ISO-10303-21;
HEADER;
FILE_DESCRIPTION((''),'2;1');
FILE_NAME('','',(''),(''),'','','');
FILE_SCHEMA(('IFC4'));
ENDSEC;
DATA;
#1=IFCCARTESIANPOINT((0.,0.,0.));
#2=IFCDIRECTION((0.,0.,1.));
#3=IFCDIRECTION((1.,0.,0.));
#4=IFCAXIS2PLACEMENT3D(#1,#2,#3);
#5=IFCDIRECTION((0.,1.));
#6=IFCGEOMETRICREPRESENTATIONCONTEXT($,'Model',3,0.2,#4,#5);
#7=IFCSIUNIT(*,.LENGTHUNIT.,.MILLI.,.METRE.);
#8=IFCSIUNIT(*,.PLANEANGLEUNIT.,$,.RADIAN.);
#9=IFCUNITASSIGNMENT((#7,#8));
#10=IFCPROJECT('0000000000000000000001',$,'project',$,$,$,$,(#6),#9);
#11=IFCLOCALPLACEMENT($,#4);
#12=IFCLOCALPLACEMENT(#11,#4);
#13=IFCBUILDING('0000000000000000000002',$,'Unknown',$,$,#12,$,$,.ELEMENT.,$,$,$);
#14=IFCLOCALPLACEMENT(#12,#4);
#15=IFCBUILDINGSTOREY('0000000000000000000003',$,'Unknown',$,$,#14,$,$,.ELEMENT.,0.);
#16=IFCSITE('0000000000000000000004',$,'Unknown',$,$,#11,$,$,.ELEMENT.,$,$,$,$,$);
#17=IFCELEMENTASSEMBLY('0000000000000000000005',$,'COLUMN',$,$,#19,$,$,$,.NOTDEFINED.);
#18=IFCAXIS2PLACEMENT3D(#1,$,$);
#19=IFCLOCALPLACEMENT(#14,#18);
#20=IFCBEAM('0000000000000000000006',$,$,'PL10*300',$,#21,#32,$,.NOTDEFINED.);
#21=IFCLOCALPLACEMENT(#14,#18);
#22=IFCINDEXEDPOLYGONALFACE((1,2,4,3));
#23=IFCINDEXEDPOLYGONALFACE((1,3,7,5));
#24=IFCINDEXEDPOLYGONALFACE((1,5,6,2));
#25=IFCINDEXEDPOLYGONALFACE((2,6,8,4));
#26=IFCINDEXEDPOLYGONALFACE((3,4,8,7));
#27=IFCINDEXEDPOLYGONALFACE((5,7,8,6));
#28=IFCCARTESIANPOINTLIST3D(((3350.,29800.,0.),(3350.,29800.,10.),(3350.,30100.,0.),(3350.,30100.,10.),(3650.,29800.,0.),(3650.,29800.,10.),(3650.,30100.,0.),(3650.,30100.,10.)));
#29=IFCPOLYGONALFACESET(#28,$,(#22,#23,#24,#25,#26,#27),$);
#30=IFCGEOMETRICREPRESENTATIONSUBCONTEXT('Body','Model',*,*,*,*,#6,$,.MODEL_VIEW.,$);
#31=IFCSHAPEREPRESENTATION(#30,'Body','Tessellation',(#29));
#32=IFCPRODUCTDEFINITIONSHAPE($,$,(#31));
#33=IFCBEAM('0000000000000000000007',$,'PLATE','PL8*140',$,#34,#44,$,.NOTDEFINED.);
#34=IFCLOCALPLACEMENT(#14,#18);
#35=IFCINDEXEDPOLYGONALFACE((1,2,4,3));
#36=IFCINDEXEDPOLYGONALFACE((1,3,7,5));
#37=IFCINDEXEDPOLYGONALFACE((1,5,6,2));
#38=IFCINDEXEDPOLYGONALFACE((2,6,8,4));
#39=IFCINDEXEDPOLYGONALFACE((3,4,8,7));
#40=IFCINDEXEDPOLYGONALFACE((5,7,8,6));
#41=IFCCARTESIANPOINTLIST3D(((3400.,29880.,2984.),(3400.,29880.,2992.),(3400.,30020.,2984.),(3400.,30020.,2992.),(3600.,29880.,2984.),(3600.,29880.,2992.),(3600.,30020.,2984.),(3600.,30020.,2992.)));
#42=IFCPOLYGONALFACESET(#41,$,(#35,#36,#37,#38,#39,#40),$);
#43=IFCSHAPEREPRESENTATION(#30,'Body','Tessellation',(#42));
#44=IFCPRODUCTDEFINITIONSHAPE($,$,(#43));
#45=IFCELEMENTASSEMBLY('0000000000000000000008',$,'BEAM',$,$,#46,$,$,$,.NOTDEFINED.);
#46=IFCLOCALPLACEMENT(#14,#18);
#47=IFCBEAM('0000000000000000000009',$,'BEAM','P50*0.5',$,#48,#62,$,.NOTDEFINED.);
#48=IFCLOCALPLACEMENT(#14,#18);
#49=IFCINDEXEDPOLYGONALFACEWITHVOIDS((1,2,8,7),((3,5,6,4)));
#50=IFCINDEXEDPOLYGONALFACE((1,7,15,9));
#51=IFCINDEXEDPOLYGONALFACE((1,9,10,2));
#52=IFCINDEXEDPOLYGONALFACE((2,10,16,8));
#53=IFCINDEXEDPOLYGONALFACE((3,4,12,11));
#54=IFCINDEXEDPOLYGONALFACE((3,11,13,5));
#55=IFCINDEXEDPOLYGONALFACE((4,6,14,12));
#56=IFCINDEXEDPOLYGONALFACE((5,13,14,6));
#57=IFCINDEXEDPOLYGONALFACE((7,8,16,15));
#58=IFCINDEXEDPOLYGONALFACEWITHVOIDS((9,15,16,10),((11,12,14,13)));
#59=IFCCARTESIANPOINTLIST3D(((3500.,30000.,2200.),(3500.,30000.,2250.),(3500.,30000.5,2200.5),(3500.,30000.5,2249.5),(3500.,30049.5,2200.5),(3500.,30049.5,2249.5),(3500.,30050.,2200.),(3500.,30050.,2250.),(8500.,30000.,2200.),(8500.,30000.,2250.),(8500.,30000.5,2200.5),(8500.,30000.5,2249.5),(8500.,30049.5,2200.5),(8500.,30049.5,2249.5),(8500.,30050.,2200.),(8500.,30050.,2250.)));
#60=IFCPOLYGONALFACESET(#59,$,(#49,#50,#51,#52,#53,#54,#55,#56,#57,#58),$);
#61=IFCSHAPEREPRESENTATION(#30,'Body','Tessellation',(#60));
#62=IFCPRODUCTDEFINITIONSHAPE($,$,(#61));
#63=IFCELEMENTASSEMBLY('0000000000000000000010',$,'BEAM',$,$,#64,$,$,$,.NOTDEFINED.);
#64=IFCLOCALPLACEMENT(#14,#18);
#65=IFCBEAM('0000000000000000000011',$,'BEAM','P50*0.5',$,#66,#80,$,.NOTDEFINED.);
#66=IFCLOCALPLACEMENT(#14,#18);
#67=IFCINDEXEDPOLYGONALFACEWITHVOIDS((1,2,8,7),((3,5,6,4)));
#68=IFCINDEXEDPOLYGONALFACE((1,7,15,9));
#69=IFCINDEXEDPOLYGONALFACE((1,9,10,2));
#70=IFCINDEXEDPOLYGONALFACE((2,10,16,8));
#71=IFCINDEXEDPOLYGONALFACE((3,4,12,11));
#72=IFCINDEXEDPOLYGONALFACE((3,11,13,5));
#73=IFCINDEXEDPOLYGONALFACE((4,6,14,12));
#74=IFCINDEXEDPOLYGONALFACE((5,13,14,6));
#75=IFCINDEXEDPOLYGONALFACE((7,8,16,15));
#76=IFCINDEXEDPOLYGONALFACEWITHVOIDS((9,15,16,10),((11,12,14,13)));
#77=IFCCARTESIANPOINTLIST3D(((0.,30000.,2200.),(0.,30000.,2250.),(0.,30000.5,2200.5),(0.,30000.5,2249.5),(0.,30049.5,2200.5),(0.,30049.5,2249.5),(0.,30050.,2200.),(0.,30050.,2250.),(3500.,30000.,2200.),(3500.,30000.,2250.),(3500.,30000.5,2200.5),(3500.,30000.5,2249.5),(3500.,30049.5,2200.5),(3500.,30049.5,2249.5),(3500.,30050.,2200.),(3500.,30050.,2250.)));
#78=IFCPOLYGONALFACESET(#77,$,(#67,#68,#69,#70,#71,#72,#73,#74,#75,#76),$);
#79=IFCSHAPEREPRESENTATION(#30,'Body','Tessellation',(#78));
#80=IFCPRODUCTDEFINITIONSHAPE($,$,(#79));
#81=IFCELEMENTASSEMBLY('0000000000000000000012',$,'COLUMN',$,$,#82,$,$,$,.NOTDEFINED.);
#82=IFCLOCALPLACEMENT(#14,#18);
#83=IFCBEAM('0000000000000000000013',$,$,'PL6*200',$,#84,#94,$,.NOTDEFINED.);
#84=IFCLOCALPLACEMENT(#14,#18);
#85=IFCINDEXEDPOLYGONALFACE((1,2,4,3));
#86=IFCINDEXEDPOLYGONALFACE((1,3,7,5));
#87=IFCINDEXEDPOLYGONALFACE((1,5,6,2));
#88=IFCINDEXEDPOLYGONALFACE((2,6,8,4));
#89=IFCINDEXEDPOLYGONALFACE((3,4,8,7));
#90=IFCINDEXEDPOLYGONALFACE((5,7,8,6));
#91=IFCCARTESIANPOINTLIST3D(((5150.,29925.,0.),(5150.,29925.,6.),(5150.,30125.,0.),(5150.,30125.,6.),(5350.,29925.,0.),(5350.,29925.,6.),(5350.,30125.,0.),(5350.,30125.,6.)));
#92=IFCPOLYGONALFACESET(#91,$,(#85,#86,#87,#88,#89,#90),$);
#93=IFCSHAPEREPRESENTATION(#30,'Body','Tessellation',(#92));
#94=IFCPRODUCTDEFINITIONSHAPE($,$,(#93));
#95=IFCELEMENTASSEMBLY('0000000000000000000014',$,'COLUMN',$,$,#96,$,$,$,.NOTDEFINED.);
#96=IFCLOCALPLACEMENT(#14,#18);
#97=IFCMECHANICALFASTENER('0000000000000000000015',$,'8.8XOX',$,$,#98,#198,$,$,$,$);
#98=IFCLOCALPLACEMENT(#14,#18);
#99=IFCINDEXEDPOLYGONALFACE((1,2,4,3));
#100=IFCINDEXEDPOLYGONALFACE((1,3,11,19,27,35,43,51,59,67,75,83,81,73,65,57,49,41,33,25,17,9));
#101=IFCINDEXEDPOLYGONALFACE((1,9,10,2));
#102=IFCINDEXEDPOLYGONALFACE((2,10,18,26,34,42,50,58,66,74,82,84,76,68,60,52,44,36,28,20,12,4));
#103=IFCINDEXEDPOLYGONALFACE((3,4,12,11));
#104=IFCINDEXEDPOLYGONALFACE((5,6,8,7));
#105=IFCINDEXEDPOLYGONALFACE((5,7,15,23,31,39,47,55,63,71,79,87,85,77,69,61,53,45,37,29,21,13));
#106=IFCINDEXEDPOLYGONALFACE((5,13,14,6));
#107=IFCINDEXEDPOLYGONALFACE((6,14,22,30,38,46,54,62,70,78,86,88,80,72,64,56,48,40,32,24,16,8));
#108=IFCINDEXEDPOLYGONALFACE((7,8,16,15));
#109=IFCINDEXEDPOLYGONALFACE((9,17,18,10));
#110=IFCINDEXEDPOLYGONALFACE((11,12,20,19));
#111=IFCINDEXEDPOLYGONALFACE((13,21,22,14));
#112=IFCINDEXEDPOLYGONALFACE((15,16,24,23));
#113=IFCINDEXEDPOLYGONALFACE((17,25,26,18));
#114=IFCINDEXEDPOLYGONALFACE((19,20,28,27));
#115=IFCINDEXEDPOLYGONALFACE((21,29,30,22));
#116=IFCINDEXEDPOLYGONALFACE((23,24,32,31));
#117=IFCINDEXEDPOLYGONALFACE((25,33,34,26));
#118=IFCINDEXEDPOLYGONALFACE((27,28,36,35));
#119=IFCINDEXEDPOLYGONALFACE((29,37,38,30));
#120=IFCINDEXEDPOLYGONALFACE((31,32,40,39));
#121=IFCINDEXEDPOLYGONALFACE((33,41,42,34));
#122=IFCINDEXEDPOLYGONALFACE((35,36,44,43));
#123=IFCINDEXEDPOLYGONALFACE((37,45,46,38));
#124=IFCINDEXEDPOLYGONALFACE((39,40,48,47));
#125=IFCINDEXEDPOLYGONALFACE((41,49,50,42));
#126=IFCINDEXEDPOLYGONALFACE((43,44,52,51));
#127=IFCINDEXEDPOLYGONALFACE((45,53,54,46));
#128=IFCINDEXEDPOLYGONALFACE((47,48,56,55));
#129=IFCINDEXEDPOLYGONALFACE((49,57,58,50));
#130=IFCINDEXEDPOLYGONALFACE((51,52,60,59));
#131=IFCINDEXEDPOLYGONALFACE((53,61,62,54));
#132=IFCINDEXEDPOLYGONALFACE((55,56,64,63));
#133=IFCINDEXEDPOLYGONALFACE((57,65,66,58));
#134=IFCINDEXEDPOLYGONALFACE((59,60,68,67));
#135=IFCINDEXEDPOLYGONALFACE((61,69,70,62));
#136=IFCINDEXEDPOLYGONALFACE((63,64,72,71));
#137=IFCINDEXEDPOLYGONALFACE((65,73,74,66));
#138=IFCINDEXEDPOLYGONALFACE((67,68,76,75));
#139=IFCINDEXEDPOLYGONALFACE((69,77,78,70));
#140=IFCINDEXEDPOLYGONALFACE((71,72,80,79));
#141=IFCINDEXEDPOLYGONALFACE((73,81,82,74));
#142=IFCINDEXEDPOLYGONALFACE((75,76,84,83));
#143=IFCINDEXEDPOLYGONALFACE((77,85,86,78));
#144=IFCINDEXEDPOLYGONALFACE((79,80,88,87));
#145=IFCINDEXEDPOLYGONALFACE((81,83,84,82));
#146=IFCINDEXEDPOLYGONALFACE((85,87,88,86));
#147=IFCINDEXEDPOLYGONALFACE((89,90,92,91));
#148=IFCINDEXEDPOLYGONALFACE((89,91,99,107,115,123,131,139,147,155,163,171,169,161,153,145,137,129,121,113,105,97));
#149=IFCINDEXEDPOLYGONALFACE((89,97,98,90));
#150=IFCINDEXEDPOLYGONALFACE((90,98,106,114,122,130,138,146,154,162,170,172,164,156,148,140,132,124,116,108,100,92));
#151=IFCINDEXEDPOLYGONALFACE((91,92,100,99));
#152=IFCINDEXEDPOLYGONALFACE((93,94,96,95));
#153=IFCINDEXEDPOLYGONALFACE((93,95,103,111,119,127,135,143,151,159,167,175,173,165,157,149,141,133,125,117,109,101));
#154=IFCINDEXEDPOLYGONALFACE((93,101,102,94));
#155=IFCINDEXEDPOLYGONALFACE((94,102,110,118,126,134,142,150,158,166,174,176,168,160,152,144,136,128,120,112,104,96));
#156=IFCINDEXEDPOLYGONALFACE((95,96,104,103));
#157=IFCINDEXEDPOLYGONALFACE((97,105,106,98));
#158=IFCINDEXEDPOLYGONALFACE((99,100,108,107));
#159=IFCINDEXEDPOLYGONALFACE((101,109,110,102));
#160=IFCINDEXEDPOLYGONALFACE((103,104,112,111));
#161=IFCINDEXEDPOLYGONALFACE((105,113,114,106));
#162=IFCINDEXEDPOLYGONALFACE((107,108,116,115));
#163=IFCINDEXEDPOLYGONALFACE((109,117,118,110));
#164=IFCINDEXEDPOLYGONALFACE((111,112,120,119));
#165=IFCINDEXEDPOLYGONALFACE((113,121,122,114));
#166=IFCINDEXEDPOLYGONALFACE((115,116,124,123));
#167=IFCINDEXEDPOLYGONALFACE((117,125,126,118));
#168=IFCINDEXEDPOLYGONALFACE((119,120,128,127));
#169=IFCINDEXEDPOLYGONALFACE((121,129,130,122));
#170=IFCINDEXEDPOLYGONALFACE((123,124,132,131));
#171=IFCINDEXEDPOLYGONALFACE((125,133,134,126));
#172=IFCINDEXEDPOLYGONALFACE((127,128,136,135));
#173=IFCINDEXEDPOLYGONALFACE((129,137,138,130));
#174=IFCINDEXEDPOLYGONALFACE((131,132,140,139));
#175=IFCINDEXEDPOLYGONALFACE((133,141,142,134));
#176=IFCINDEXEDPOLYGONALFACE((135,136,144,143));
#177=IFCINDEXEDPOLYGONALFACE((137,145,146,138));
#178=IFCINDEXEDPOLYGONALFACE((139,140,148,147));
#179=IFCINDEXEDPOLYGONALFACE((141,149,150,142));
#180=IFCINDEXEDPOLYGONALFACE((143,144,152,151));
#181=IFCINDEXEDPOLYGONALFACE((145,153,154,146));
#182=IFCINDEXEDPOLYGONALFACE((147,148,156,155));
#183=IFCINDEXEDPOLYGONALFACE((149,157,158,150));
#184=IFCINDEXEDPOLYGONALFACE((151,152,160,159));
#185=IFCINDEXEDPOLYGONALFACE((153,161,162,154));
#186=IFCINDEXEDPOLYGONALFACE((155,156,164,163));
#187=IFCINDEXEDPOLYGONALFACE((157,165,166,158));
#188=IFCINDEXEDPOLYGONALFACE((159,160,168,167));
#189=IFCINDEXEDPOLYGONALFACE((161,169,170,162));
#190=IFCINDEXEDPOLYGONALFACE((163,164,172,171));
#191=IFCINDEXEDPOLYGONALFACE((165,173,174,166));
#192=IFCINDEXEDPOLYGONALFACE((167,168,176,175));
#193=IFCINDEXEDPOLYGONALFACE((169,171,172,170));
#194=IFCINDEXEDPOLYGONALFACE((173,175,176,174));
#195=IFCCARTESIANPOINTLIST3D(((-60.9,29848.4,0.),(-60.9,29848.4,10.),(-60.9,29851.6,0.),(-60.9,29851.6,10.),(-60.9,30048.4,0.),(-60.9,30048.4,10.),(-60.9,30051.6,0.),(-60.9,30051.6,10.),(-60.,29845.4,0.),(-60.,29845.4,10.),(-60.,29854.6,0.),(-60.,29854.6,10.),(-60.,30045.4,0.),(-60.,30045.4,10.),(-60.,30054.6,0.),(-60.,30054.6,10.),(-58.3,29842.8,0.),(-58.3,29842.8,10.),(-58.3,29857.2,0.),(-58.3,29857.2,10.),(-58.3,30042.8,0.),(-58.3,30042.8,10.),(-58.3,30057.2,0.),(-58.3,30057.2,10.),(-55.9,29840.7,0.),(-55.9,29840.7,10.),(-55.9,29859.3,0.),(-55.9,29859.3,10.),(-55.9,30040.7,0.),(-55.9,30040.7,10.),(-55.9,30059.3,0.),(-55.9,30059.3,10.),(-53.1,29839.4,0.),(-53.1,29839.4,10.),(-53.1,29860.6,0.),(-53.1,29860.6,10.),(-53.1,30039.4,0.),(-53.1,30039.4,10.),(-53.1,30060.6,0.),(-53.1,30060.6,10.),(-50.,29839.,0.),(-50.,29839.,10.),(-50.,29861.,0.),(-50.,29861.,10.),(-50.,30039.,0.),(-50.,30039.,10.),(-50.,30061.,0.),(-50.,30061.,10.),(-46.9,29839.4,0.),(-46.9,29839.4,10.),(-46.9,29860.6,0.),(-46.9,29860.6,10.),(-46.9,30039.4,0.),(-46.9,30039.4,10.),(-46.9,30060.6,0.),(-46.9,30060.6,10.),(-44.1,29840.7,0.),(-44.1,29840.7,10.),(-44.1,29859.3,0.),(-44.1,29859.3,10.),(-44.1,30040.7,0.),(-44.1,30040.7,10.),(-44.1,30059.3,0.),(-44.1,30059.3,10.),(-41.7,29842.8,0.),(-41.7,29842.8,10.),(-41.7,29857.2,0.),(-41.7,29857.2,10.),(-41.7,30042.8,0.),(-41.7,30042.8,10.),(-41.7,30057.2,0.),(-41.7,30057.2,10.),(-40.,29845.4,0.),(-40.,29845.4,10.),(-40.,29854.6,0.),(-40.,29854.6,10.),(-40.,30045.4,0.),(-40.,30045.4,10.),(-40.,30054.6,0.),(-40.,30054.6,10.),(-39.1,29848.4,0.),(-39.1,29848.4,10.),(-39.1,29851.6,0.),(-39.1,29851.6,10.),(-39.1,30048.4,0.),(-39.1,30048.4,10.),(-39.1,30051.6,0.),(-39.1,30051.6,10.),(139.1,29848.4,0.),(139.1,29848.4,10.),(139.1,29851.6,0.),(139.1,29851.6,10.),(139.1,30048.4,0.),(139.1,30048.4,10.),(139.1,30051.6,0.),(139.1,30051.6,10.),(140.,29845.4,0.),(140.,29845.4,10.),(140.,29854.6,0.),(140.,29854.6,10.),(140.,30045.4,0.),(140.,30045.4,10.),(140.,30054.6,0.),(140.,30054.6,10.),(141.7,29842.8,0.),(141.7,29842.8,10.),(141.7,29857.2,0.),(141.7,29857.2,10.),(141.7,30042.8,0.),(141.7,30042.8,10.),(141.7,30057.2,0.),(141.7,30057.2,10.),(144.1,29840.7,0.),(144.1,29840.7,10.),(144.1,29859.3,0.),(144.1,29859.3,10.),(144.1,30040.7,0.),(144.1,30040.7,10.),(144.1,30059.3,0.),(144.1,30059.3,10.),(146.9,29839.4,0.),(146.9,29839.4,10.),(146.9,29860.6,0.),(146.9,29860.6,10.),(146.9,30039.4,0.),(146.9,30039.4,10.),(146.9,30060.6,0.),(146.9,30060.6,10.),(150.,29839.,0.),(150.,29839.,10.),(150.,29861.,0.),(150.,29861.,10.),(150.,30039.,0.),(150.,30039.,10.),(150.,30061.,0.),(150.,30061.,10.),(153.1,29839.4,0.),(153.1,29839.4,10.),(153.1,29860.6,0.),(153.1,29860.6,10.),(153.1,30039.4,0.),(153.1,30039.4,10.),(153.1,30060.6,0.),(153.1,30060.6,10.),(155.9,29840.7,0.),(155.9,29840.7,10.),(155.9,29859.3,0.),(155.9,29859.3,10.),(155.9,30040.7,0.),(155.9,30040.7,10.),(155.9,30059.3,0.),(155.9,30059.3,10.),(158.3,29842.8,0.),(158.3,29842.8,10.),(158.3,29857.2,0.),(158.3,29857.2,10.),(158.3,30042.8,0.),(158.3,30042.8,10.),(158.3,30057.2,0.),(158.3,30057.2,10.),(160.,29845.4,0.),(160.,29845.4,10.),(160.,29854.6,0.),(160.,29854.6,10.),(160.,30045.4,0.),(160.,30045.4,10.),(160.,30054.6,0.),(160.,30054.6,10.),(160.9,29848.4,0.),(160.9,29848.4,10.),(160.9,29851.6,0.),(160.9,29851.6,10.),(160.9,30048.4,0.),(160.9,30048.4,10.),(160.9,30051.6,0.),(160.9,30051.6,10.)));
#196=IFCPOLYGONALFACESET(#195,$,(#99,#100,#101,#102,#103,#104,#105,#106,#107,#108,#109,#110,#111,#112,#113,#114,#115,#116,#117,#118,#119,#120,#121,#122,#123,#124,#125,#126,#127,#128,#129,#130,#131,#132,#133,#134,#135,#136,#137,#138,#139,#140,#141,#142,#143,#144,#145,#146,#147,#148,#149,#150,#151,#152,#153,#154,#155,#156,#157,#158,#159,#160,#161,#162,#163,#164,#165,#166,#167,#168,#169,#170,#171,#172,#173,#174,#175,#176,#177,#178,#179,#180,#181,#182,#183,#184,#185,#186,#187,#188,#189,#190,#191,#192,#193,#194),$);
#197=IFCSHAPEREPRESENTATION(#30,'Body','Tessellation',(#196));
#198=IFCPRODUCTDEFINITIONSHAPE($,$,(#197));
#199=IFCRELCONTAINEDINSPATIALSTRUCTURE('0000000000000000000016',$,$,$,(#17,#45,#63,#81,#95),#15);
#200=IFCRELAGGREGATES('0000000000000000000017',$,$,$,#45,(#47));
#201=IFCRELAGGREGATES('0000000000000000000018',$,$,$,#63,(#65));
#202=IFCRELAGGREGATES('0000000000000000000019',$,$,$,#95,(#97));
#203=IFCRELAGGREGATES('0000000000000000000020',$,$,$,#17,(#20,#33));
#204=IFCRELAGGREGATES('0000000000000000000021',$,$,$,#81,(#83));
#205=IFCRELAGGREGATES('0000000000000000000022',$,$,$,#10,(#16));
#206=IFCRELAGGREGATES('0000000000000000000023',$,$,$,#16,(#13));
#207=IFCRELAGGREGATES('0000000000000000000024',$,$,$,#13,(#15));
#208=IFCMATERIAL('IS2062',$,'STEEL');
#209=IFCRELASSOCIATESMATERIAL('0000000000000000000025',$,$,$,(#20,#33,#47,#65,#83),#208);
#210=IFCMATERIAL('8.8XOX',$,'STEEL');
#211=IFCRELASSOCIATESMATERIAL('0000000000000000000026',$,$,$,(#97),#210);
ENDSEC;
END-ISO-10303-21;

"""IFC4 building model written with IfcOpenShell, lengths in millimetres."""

from ifc_helpers import new_model, si_unit, direction, frame, origin_with_axes, place, context, subcontext, project, spatial, line, arc, indexed_curve, outline, extrude, source, transform, mapped, material, element, aggregate, save


model = new_model("IFC4")

# Units and contexts
model_context = context("Model", 3, precision=0.2, world=origin_with_axes(), true_north=direction((0.0, 1.0)))
body_context = subcontext(model_context, "Body", "Model", "MODEL_VIEW")
ifc_project = project(units=[si_unit("LENGTHUNIT", "METRE", prefix="MILLI"), si_unit("PLANEANGLEUNIT", "RADIAN")], contexts=[model_context])

# Site, building, storey
site_placement = place(None, origin_with_axes())
site = spatial("IfcSite", under=ifc_project, at=site_placement, Name="Unknown", CompositionType="ELEMENT")
building_placement = place(site_placement, origin_with_axes())
building = spatial("IfcBuilding", under=site, at=building_placement, Name="Unknown", CompositionType="ELEMENT")
storey_placement = place(building_placement, origin_with_axes())
storey = spatial("IfcBuildingStorey", under=building, at=storey_placement, Name="Unknown", CompositionType="ELEMENT", Elevation=0.0)

# Shared definitions
ifc_material_1 = material(Name="IS2062", Category="STEEL")

# Element assembly, beams
assembly_1_placement = place(storey_placement, frame((3500.0, 29950.0, 0.0), z_axis=(0.0, 1.0, 0.0), x_axis=(0.0, 0.0, 1.0)))
assembly_1 = element("IfcElementAssembly", 1, at=assembly_1_placement, inside=storey, Name="COLUMN", PredefinedType="NOTDEFINED")
beam_1_placement = place(assembly_1_placement, frame((5.0, -150.0, 0.0), z_axis=(1.0, 0.0, 0.0), x_axis=(0.0, 1.0, 0.0)))
beam_1 = element("IfcBeam", 2, at=beam_1_placement, material=ifc_material_1, Description="PL10*300", PredefinedType="NOTDEFINED", context=body_context, shape_type="SolidModel", body=[
    extrude(outline(indexed_curve([(-5.0, -150.0), (5.0, -150.0), (5.0, 150.0), (-5.0, 150.0)], segments=[line(1, 2, 3, 4, 1)])), frame((0.0, 0.0, 0.0), z_axis=(-1.0, 0.0, 0.0), x_axis=(0.0, 0.0, 1.0)), (0.0, 0.0, -1.0), 300.0),
])
beam_2_placement = place(assembly_1_placement, frame((2988.0, -100.0, 0.0), z_axis=(-1.0, 0.0, 0.0), x_axis=(0.0, 1.0, 0.0)))
beam_2 = element("IfcBeam", 3, at=beam_2_placement, material=ifc_material_1, Name="PLATE", Description="PL8*140", PredefinedType="NOTDEFINED", context=body_context, shape_type="SolidModel", body=[
    extrude(outline(indexed_curve([(-4.0, -70.0), (4.0, -70.0), (4.0, 70.0), (-4.0, 70.0)], segments=[line(1, 2, 3, 4, 1)])), frame((0.0, 0.0, 0.0), z_axis=(-1.0, 0.0, 0.0), x_axis=(0.0, 0.0, 1.0)), (0.0, 0.0, -1.0), 200.0),
])

# Element assemblies, beams
assembly_2_placement = place(storey_placement, frame((3500.0, 30025.0, 2225.0), z_axis=(0.0, -1.0, 0.0), x_axis=(1.0, 0.0, 0.0)))
assembly_2 = element("IfcElementAssembly", 4, at=assembly_2_placement, inside=storey, Name="BEAM", PredefinedType="NOTDEFINED")
beam_3_placement = place(assembly_2_placement, origin_with_axes())
beam_3 = element("IfcBeam", 5, at=beam_3_placement, material=ifc_material_1, Name="BEAM", Description="P50*0.5", PredefinedType="NOTDEFINED", context=body_context, shape_type="SolidModel", body=[
    extrude(outline(indexed_curve([(-25.0, -25.0), (25.0, -25.0), (25.0, 25.0), (-25.0, 25.0)], segments=[line(1, 2, 3, 4, 1)]), holes=[indexed_curve([(-24.5, -24.5), (-24.5, 24.5), (24.5, 24.5), (24.5, -24.5)], segments=[line(1, 2, 3, 4, 1)])]), frame((0.0, 0.0, 0.0), z_axis=(-1.0, 0.0, 0.0), x_axis=(0.0, 0.0, 1.0)), (0.0, 0.0, -1.0), 5000.0),
])
aggregate(assembly_2, [beam_3])
assembly_3_placement = place(storey_placement, frame((3500.0, 30025.0, 2225.0), z_axis=(0.0, 1.0, 0.0), x_axis=(-1.0, 0.0, 0.0)))
assembly_3 = element("IfcElementAssembly", 6, at=assembly_3_placement, inside=storey, Name="BEAM", PredefinedType="NOTDEFINED")
beam_4_placement = place(assembly_3_placement, origin_with_axes())
beam_4 = element("IfcBeam", 7, at=beam_4_placement, material=ifc_material_1, Name="BEAM", Description="P50*0.5", PredefinedType="NOTDEFINED", context=body_context, shape_type="SolidModel", body=[
    extrude(outline(indexed_curve([(-25.0, -25.0), (25.0, -25.0), (25.0, 25.0), (-25.0, 25.0)], segments=[line(1, 2, 3, 4, 1)]), holes=[indexed_curve([(-24.5, -24.5), (-24.5, 24.5), (24.5, 24.5), (24.5, -24.5)], segments=[line(1, 2, 3, 4, 1)])]), frame((0.0, 0.0, 0.0), z_axis=(-1.0, 0.0, 0.0), x_axis=(0.0, 0.0, 1.0)), (0.0, 0.0, -1.0), 3500.0),
])
aggregate(assembly_3, [beam_4])
assembly_4_placement = place(storey_placement, frame((5250.0, 30025.0, 0.0), z_axis=(0.0, 1.0, 0.0), x_axis=(0.0, 0.0, 1.0)))
assembly_4 = element("IfcElementAssembly", 8, at=assembly_4_placement, inside=storey, Name="COLUMN", PredefinedType="NOTDEFINED")
beam_5_placement = place(assembly_4_placement, frame((3.0, -100.0, 0.0), z_axis=(1.0, 0.0, 0.0), x_axis=(0.0, 1.0, 0.0)))
beam_5 = element("IfcBeam", 9, at=beam_5_placement, material=ifc_material_1, Description="PL6*200", PredefinedType="NOTDEFINED", context=body_context, shape_type="SolidModel", body=[
    extrude(outline(indexed_curve([(-3.0, -100.0), (3.0, -100.0), (3.0, 100.0), (-3.0, 100.0)], segments=[line(1, 2, 3, 4, 1)])), frame((0.0, 0.0, 0.0), z_axis=(-1.0, 0.0, 0.0), x_axis=(0.0, 0.0, 1.0)), (0.0, 0.0, -1.0), 200.0),
])

# Element assembly, mechanical fastener
assembly_5_placement = place(storey_placement, frame((50.0, 29950.0, 0.0), z_axis=(0.0, 1.0, 0.0), x_axis=(0.0, 0.0, 1.0)))
assembly_5 = element("IfcElementAssembly", 10, at=assembly_5_placement, inside=storey, Name="COLUMN", PredefinedType="NOTDEFINED")
ifc_material_2 = material(Name="8.8XOX", Category="STEEL")
shared_shape_1 = source(origin_with_axes(), body_context, "Body", "SweptSolid", [
    extrude(outline(indexed_curve([(11.0, 0.0), (0.0, 11.0), (-11.0, 0.0), (0.0, -11.0)], segments=[arc(1, 2, 3), arc(3, 4, 1)])), frame((0.0, 0.0, 0.0), z_axis=(0.0, 0.0, -1.0), x_axis=(0.0, 1.0, 0.0)), (0.0, 0.0, 1.0), 10.0),
])
mechanical_fastener_1_placement = place(assembly_5_placement, frame((10.0, 50.0, 0.0), z_axis=(1.0, 0.0, 0.0), x_axis=(0.0, -1.0, 0.0)))
mechanical_fastener_1 = element("IfcMechanicalFastener", 11, at=mechanical_fastener_1_placement, material=ifc_material_2, Name="8.8XOX", context=body_context, shape_type="MappedRepresentation", body=[
    mapped(shared_shape_1, transform((-50.0, 100.0, 0.0))),
    mapped(shared_shape_1, transform((-50.0, -100.0, 0.0))),
    mapped(shared_shape_1, transform((150.0, 100.0, 0.0))),
    mapped(shared_shape_1, transform((150.0, -100.0, 0.0))),
])
aggregate(assembly_5, [mechanical_fastener_1])

aggregate(assembly_1, [beam_1, beam_2])

aggregate(assembly_4, [beam_5])

save(model, "model.ifc")
